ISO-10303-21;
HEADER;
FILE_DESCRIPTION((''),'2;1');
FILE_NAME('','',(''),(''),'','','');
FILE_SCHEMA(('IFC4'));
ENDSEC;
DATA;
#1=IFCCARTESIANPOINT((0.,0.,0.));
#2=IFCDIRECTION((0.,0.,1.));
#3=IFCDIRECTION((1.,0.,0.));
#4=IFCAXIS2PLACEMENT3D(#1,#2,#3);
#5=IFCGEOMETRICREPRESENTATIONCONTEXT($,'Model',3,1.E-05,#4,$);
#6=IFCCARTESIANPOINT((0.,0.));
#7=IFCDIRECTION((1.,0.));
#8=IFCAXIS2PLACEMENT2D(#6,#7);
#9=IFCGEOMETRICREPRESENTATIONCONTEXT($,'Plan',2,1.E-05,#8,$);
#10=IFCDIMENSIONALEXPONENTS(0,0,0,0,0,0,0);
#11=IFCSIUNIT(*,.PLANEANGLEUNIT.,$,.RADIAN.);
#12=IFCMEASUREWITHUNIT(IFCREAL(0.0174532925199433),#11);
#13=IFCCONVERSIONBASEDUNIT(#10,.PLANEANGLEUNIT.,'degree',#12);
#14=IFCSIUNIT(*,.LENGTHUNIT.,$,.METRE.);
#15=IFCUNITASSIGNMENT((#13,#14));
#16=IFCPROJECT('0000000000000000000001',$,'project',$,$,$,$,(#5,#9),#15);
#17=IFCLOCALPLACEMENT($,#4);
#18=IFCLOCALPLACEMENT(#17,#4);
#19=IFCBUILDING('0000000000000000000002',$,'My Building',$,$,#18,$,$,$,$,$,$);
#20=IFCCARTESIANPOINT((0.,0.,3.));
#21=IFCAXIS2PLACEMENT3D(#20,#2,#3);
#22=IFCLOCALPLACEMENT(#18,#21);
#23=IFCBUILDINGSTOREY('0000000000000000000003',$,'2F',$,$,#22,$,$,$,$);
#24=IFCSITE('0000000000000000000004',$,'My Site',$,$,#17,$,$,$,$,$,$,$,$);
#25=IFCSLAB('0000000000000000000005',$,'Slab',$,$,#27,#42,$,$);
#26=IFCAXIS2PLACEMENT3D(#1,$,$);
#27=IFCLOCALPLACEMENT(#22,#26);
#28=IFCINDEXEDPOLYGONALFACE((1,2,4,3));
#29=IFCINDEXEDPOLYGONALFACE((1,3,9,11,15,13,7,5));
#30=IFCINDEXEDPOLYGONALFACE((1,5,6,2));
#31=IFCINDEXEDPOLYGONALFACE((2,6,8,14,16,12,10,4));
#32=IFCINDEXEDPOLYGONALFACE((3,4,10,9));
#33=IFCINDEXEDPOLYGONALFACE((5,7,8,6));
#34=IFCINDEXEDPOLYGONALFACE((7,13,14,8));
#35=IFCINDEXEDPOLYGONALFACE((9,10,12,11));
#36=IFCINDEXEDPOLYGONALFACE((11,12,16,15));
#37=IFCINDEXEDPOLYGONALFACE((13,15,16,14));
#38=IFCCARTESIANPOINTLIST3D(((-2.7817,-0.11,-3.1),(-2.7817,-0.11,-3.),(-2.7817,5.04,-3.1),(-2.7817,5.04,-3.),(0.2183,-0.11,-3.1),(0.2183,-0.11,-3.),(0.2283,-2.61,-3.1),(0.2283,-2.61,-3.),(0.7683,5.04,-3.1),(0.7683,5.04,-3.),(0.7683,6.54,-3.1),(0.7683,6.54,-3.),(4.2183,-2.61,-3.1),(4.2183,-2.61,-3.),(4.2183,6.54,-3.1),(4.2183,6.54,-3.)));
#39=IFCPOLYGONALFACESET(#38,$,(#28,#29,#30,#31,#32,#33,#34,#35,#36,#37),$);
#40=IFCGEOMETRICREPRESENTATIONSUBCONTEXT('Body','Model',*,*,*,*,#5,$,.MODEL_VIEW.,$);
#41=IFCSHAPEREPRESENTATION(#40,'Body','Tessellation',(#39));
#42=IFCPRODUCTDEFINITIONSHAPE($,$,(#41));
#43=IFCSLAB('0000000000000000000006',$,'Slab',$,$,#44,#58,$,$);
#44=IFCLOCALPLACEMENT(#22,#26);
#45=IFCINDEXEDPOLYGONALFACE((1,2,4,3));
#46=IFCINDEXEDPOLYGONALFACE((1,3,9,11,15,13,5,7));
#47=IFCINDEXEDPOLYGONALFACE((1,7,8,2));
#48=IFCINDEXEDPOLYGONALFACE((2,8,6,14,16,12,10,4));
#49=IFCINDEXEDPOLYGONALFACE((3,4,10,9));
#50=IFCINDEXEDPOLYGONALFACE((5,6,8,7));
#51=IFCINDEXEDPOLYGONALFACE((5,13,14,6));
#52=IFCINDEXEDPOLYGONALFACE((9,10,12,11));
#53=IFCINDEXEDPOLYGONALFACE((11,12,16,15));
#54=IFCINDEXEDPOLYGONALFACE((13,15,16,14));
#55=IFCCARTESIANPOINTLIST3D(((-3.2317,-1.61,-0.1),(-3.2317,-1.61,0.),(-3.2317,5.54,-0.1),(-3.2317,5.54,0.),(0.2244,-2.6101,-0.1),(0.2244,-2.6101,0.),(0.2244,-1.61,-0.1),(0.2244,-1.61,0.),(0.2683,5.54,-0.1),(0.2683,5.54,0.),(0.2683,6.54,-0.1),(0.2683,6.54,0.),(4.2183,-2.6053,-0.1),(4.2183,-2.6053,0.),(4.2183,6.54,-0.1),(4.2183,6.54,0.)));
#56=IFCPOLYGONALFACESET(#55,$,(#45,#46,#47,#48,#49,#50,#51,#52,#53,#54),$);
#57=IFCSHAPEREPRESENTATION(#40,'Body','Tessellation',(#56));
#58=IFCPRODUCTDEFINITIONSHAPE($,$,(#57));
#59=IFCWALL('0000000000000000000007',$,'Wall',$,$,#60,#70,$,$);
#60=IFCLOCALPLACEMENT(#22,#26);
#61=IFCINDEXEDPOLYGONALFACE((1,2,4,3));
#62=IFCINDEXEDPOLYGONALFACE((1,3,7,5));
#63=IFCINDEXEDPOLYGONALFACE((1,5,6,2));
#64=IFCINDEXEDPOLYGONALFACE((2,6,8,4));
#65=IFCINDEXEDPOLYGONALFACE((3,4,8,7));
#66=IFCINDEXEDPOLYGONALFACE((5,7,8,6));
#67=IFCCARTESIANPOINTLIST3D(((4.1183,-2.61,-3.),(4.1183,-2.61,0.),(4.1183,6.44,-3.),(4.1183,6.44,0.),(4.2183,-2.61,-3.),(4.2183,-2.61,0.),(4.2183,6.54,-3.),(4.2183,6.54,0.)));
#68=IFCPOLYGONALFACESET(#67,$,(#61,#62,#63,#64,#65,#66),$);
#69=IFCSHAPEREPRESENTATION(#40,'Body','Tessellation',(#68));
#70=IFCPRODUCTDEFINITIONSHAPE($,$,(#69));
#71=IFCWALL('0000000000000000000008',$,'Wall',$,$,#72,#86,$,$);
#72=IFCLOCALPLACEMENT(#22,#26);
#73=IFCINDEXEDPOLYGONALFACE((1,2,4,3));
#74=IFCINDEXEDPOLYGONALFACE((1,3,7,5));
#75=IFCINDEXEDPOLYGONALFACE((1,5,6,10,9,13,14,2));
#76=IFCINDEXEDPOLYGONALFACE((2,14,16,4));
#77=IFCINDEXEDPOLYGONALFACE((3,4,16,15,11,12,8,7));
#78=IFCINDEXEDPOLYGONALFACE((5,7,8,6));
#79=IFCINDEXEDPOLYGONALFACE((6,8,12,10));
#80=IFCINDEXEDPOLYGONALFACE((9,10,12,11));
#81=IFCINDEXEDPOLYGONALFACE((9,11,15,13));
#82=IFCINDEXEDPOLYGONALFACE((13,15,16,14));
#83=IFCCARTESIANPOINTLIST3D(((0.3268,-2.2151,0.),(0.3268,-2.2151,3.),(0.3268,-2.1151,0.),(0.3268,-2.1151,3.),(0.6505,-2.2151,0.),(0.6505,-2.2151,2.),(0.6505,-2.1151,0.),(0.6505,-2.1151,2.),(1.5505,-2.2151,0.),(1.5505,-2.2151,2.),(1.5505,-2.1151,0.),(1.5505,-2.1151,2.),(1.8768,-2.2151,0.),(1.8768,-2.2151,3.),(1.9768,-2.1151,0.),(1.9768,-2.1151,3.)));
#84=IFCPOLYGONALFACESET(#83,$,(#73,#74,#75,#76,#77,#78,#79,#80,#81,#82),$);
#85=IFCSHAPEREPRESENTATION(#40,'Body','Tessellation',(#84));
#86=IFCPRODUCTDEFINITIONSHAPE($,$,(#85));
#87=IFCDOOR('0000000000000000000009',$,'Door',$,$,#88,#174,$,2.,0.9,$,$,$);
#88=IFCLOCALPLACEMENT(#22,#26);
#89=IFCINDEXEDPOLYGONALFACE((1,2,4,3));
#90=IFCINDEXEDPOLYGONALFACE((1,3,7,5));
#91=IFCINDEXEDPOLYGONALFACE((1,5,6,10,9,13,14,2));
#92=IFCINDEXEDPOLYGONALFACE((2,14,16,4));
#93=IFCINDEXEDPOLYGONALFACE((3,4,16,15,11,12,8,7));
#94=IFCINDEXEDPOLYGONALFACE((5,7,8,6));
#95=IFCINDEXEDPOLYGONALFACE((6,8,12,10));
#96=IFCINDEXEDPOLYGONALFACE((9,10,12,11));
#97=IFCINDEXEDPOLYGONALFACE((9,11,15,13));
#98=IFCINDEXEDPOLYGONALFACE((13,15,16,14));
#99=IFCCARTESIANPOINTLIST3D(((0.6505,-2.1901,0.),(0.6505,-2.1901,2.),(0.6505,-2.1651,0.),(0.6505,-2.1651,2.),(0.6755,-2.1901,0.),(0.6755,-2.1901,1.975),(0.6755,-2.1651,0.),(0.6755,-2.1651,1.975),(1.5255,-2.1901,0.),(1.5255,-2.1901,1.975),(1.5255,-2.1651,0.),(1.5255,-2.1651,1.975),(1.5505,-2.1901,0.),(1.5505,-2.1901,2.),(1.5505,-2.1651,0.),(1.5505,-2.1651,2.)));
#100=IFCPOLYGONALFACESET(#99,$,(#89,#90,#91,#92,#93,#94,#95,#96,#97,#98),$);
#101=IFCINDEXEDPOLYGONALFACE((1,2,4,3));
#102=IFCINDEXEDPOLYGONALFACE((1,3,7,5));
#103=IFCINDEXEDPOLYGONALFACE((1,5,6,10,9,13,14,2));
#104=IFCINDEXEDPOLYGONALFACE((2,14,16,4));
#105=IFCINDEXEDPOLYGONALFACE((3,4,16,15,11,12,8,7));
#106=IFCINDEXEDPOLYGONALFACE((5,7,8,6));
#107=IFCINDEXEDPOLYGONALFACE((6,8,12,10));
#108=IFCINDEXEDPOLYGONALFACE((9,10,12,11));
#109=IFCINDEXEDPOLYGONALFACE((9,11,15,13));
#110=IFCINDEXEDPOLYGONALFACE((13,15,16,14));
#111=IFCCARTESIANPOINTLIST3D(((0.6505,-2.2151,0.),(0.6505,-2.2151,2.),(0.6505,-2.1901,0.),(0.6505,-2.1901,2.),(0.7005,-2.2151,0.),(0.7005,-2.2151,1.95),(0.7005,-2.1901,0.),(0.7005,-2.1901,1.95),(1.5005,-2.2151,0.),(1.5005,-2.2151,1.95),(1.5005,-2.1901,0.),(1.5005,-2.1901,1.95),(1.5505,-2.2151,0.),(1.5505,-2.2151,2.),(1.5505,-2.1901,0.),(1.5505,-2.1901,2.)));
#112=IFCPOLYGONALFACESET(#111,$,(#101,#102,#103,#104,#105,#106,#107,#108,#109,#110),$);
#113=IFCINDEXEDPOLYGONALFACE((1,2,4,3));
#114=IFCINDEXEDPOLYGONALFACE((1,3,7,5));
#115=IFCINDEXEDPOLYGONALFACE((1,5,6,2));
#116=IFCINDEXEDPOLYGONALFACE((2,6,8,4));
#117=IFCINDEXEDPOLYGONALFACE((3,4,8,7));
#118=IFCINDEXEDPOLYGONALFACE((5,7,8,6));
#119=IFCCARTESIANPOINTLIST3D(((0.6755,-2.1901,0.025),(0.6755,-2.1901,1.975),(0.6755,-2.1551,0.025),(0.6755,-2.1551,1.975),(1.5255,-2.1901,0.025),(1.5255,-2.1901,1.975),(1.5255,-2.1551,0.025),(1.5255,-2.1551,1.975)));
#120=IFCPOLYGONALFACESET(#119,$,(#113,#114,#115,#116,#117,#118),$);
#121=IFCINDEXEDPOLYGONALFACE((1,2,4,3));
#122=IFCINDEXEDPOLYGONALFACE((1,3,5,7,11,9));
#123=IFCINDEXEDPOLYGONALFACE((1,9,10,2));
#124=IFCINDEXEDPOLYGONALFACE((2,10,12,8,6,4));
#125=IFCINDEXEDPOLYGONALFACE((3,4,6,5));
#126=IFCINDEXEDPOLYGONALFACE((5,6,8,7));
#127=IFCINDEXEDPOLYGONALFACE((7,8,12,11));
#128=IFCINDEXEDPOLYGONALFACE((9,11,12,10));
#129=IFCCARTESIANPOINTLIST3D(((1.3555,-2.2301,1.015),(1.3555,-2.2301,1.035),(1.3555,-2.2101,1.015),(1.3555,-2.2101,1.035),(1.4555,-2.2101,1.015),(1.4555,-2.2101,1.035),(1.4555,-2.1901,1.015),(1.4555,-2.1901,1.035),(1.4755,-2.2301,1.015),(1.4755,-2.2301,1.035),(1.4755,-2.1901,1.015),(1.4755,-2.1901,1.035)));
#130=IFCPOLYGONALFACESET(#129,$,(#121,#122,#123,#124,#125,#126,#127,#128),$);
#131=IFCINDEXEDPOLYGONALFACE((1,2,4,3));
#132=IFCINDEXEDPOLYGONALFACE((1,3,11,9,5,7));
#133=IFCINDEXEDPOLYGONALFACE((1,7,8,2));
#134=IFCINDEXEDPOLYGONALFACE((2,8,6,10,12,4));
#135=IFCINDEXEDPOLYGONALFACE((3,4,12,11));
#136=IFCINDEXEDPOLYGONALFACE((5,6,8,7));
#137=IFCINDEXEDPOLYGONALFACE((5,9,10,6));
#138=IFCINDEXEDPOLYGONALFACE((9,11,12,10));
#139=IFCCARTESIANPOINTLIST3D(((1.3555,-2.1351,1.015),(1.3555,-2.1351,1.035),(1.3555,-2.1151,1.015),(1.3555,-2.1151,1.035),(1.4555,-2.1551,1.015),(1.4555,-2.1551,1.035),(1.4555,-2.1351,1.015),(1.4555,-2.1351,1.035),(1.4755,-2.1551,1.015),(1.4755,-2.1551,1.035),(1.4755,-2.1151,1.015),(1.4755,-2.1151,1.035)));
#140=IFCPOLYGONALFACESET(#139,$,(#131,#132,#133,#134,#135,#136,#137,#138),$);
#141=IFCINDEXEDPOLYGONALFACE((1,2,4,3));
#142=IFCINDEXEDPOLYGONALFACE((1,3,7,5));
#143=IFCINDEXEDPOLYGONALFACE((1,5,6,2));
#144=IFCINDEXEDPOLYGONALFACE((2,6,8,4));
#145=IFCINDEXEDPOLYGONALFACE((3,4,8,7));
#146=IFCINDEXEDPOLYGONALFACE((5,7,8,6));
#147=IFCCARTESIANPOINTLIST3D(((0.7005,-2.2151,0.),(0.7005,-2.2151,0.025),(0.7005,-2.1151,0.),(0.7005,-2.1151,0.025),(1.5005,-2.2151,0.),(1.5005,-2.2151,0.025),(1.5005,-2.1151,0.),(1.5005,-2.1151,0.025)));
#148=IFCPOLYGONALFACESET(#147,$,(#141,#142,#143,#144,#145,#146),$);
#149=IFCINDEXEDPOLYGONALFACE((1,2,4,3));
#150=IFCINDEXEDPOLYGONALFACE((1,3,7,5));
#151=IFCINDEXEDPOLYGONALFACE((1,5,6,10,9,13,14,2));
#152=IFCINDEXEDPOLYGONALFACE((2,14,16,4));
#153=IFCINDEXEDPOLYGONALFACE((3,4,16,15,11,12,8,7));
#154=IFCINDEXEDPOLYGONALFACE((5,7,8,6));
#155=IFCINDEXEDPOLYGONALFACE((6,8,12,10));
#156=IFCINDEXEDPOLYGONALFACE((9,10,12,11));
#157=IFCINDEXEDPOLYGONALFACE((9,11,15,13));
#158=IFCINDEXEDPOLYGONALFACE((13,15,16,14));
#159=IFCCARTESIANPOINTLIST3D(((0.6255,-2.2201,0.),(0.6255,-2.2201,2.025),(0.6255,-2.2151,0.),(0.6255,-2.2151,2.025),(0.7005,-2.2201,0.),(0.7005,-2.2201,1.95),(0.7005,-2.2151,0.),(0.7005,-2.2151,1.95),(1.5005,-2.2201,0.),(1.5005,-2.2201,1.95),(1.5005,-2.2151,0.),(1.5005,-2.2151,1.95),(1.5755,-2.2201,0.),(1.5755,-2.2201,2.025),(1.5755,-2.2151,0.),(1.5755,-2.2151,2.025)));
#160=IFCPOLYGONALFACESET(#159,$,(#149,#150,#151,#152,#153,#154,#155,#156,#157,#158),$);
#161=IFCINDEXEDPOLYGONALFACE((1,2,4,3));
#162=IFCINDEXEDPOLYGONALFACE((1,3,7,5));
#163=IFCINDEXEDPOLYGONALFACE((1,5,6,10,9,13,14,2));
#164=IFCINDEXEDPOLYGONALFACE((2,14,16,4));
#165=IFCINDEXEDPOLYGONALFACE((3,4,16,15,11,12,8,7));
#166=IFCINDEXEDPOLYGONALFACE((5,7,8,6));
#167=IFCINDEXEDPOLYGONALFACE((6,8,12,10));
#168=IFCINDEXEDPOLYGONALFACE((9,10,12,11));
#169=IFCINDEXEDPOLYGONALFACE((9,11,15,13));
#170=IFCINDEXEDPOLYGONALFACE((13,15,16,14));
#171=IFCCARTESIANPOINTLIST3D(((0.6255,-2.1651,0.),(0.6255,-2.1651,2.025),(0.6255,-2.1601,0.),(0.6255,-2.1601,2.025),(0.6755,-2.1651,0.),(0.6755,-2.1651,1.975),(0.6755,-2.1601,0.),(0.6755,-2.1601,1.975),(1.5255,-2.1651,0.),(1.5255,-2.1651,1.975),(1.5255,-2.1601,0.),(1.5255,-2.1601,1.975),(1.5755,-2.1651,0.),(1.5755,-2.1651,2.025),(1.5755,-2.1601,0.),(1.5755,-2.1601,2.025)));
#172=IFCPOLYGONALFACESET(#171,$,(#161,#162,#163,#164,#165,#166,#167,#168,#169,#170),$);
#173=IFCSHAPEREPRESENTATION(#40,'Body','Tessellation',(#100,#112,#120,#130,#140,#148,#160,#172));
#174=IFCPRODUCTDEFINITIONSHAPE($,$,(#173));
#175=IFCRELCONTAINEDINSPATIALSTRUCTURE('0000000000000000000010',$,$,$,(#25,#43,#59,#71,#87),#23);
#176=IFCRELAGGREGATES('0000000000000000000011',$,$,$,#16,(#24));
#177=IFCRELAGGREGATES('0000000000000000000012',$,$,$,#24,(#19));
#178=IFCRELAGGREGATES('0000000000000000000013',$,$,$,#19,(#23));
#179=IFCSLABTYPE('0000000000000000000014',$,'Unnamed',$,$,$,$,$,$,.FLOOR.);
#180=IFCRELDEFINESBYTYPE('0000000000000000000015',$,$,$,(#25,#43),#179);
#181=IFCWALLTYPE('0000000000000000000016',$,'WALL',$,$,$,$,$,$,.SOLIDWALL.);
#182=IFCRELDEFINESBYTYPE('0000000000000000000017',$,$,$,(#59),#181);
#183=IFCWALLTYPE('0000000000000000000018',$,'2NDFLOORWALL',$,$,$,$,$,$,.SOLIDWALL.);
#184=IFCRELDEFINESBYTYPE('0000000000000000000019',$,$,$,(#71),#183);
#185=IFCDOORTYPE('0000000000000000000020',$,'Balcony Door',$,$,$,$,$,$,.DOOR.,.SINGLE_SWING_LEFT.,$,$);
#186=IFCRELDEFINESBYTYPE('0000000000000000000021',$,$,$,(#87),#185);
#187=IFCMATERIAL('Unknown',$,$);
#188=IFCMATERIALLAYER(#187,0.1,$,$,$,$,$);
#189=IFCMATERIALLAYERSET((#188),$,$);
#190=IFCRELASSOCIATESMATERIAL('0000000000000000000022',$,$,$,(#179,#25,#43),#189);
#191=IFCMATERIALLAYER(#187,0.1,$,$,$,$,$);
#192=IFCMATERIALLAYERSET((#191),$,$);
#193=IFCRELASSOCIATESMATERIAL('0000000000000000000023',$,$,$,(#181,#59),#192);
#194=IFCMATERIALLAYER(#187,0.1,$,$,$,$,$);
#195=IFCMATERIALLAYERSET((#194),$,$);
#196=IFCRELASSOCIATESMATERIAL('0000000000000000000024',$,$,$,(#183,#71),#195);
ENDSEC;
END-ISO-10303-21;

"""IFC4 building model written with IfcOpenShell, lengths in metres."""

from ifc_helpers import new_model, entity, si_unit, converted_unit, frame, origin_with_axes, origin_2d_with_axis, place, context, subcontext, project, spatial, line, indexed_curve, outline, extrude, shape, source, transform, mapped, material, layer, layer_set, layer_usage, type_object, type_shapes, element, fill, save


model = new_model("IFC4")

# Units and contexts
model_context = context("Model", 3, precision=1e-05, world=origin_with_axes())
plan_context = context("Plan", 2, precision=1e-05, world=origin_2d_with_axis())
body_context_1 = subcontext(model_context, "Body", "Model", "MODEL_VIEW")
body_context_2 = subcontext(plan_context, "Body", "Plan", "PLAN_VIEW")
ifc_project = project(units=[converted_unit("PLANEANGLEUNIT", "degree", entity("IfcReal", 0.0174532925199433), si_unit("PLANEANGLEUNIT", "RADIAN"), dimensions=[0, 0, 0, 0, 0, 0, 0]), si_unit("LENGTHUNIT", "METRE")], contexts=[model_context, plan_context])

# Site, building, storey
site_placement = place(None, origin_with_axes())
site = spatial("IfcSite", under=ifc_project, at=site_placement, Name="My Site")
building_placement = place(site_placement, origin_with_axes())
building = spatial("IfcBuilding", under=site, at=building_placement, Name="My Building")
storey_placement = place(building_placement, frame((0.0, 0.0, 3.0), z_axis=(0.0, 0.0, 1.0), x_axis=(1.0, 0.0, 0.0)))
storey = spatial("IfcBuildingStorey", under=building, at=storey_placement, Name="2F")

# Slabs
ifc_material = material(Name="Unknown")
ifc_layer_1 = layer(ifc_material, 0.1)
ifc_layer_set_1 = layer_set([ifc_layer_1])
ifc_layer_usage_1 = layer_usage(ifc_layer_set_1, "AXIS3", "POSITIVE", -0.1)
slab_type = type_object("IfcSlabType", Name="Unnamed", PredefinedType="FLOOR", material=ifc_layer_set_1)
slab_1_placement = place(storey_placement, frame((4.2183, -2.61, -3.0), z_axis=(0.0, 0.0, 1.0), x_axis=(1.0, 0.0, 0.0)))
element("IfcSlab", 1, at=slab_1_placement, inside=storey, type_object=slab_type, material=ifc_layer_usage_1, Name="Slab", context=body_context_1, shape_type="SweptSolid", body=[
    extrude(outline(indexed_curve([(0.0, 0.0), (0.0, 9.15), (-3.45, 9.15), (-3.45, 7.65), (-7.0, 7.65), (-7.0, 2.5), (-4.0, 2.5), (-3.99, 0.0), (0.0, 0.0)])), frame((0.0, 0.0, -0.1), z_axis=(0.0, 0.0, 1.0), x_axis=(1.0, 0.0, 0.0)), (0.0, 0.0, 1.0), 0.1),
])
ifc_layer_usage_2 = layer_usage(ifc_layer_set_1, "AXIS3", "POSITIVE", -0.1)
slab_2_placement = place(storey_placement, frame((4.2183, -2.6053, 0.0), z_axis=(0.0, 0.0, 1.0), x_axis=(1.0, 0.0, 0.0)))
element("IfcSlab", 2, at=slab_2_placement, inside=storey, type_object=slab_type, material=ifc_layer_usage_2, Name="Slab", context=body_context_1, shape_type="SweptSolid", body=[
    extrude(outline(indexed_curve([(0.0, 0.0), (-3.9939, -0.0048), (-3.9939, 0.9953), (-7.45, 0.9953), (-7.45, 8.1453), (-3.95, 8.1453), (-3.95, 9.1453), (0.0, 9.1453), (0.0, 0.0), (0.0, 0.0)])), frame((0.0, 0.0, -0.1), z_axis=(0.0, 0.0, 1.0), x_axis=(1.0, 0.0, 0.0)), (0.0, 0.0, 1.0), 0.1),
])

# Wall
ifc_layer_2 = layer(ifc_material, 0.1)
ifc_layer_set_2 = layer_set([ifc_layer_2])
ifc_layer_usage_3 = layer_usage(ifc_layer_set_2, "AXIS2", "POSITIVE", 0.0)
wall_type_1 = type_object("IfcWallType", Name="WALL", PredefinedType="SOLIDWALL", material=ifc_layer_set_2)
wall_1_placement = place(storey_placement, frame((4.2183, -2.61, -3.0), z_axis=(0.0, 0.0, 1.0), x_axis=(0.0, 1.0, 0.0)))
element("IfcWall", 3, at=wall_1_placement, inside=storey, type_object=wall_type_1, material=ifc_layer_usage_3, Name="Wall", context=body_context_1, shape_type="SweptSolid", body=[
    extrude(outline(indexed_curve([(0.0, 0.0), (0.0, 0.1), (9.05, 0.1), (9.15, 0.0)], segments=[line(1, 2, 3, 4, 1)])), origin_with_axes(), (0.0, 0.0, 1.0), 3.0),
])

# Wall, opening, door
ifc_layer_3 = layer(ifc_material, 0.1)
ifc_layer_set_3 = layer_set([ifc_layer_3])
ifc_layer_usage_4 = layer_usage(ifc_layer_set_3, "AXIS2", "POSITIVE", 0.0)
wall_type_2 = type_object("IfcWallType", Name="2NDFLOORWALL", PredefinedType="SOLIDWALL", material=ifc_layer_set_3)
wall_2_placement = place(storey_placement, frame((0.3268, -2.2151, 0.0), z_axis=(0.0, 0.0, 1.0), x_axis=(1.0, 0.0, 0.0)))
wall_2 = element("IfcWall", 4, at=wall_2_placement, inside=storey, type_object=wall_type_2, material=ifc_layer_usage_4, Name="Wall", context=body_context_1, shape_type="SweptSolid", body=[
    extrude(outline(indexed_curve([(0.0, 0.0), (0.0, 0.1), (1.65, 0.1), (1.55, 0.0)], segments=[line(1, 2, 3, 4, 1)])), origin_with_axes(), (0.0, 0.0, 1.0), 3.0),
])
shared_shape_1 = source(origin_with_axes(), body_context_1, "Body", "SweptSolid", [
    extrude(outline(indexed_curve([(0.0, 0.0), (0.9, 0.0), (0.9, 2.0), (0.0, 2.0)], segments=[line(1, 2, 3, 4, 1)])), frame((0.0, -0.6, 0.0), z_axis=(0.0, -1.0, 0.0), x_axis=(1.0, 0.0, 0.0)), (0.0, 0.0, -1.0), 1.2),
])
opening_1_placement = place(wall_2_placement, frame((0.3237, 0.0, 0.0), z_axis=(0.0, 0.0, 1.0), x_axis=(1.0, 0.0, 0.0)))
opening_1 = element("IfcOpeningElement", 5, at=opening_1_placement, cuts=wall_2, PredefinedType="OPENING", context=body_context_1, shape_type="MappedRepresentation", body=[
    mapped(shared_shape_1, transform((0.0, 0.0, 0.0), x_axis=(1.0, 0.0, 0.0), y_axis=(0.0, 1.0, 0.0), z_axis=(0.0, 0.0, 1.0), scale=1.0)),
])
door_type_1 = type_object("IfcDoorType", Name="Balcony Door", OperationType="SINGLE_SWING_LEFT", PredefinedType="DOOR")
shared_shape_2 = source(origin_with_axes(), body_context_1, "Body", "SweptSolid", [
    extrude(outline(indexed_curve([(0.0, 0.0), (0.0, 2.0), (0.9, 2.0), (0.9, 0.0), (0.875, 0.0), (0.875, 1.975), (0.025, 1.975), (0.025, 0.0)], segments=[line(1, 2, 3, 4, 5, 6, 7, 8, 1)])), frame((0.0, 0.025, 0.0), z_axis=(0.0, -1.0, 0.0), x_axis=(1.0, 0.0, 0.0)), (0.0, 0.0, -1.0), 0.025),
    extrude(outline(indexed_curve([(0.0, 0.0), (0.0, 2.0), (0.9, 2.0), (0.9, 0.0), (0.85, 0.0), (0.85, 1.95), (0.05, 1.95), (0.05, 0.0)], segments=[line(1, 2, 3, 4, 5, 6, 7, 8, 1)])), frame((0.0, 0.0, 0.0), z_axis=(0.0, -1.0, 0.0), x_axis=(1.0, 0.0, 0.0)), (0.0, 0.0, -1.0), 0.025),
    extrude(outline(indexed_curve([(0.0, 0.0), (0.85, 0.0), (0.85, 0.035), (0.0, 0.035)], segments=[line(1, 2, 3, 4, 1)])), frame((0.025, 0.025, 0.025), z_axis=(0.0, 0.0, 1.0), x_axis=(1.0, 0.0, 0.0)), (0.0, 0.0, 1.0), 1.95),
    extrude(outline(indexed_curve([(0.0, 0.0), (0.0, -0.04), (-0.12, -0.04), (-0.12, -0.02), (-0.02, -0.02), (-0.02, 0.0)], segments=[line(1, 2, 3, 4, 5, 6, 1)])), frame((0.825, 0.025, 1.015), z_axis=(0.0, 0.0, 1.0), x_axis=(1.0, 0.0, 0.0)), (0.0, 0.0, 1.0), 0.02),
    extrude(outline(indexed_curve([(0.0, 0.0), (0.0, 0.04), (-0.12, 0.04), (-0.12, 0.02), (-0.02, 0.02), (-0.02, 0.0)], segments=[line(1, 2, 3, 4, 5, 6, 1)])), frame((0.825, 0.06, 1.015), z_axis=(0.0, 0.0, 1.0), x_axis=(1.0, 0.0, 0.0)), (0.0, 0.0, 1.0), 0.02),
    extrude(outline(indexed_curve([(0.0, 0.0), (0.8, 0.0), (0.8, 0.1), (0.0, 0.1)], segments=[line(1, 2, 3, 4, 1)])), frame((0.05, 0.0, 0.0), z_axis=(0.0, 0.0, 1.0), x_axis=(1.0, 0.0, 0.0)), (0.0, 0.0, 1.0), 0.025),
    extrude(outline(indexed_curve([(0.0, 0.0), (0.0, 2.025), (0.95, 2.025), (0.95, 0.0), (0.875, 0.0), (0.875, 1.95), (0.075, 1.95), (0.075, 0.0)], segments=[line(1, 2, 3, 4, 5, 6, 7, 8, 1)])), frame((-0.025, -0.005, 0.0), z_axis=(0.0, -1.0, 0.0), x_axis=(1.0, 0.0, 0.0)), (0.0, 0.0, -1.0), 0.005),
    extrude(outline(indexed_curve([(0.0, 0.0), (0.0, 2.025), (0.95, 2.025), (0.95, 0.0), (0.9, 0.0), (0.9, 1.975), (0.05, 1.975), (0.05, 0.0)], segments=[line(1, 2, 3, 4, 5, 6, 7, 8, 1)])), frame((-0.025, 0.05, 0.0), z_axis=(0.0, -1.0, 0.0), x_axis=(1.0, 0.0, 0.0)), (0.0, 0.0, -1.0), 0.005),
])
shared_shape_3 = source(origin_with_axes(), body_context_2, "Body", "Curve2D", [
    entity("IfcIndexedPolyCurve", entity("IfcCartesianPointList2D", [[0.0, 0.0], [0.0, 0.05], [0.025, 0.05], [0.025, 0.025], [0.05, 0.025], [0.05, 0.0]]), [entity("IfcLineIndex", [1, 2, 3, 4, 5, 6, 1])]),
    entity("IfcIndexedPolyCurve", entity("IfcCartesianPointList2D", [[0.9, 0.0], [0.9, 0.05], [0.875, 0.05], [0.875, 0.025], [0.85, 0.025], [0.85, 0.0]]), [entity("IfcLineIndex", [1, 2, 3, 4, 5, 6, 1])]),
    entity("IfcTrimmedCurve", entity("IfcEllipse", entity("IfcAxis2Placement2D", entity("IfcCartesianPoint", [0.06, 0.05]), entity("IfcDirection", [1.0, 0.0])), 0.815, 0.85), [entity("IfcCartesianPoint", [0.875, 0.05])], [entity("IfcCartesianPoint", [0.06, 0.9])], True, "CARTESIAN"),
    entity("IfcIndexedPolyCurve", entity("IfcCartesianPointList2D", [[0.025, 0.05], [0.06, 0.05], [0.06, 0.9], [0.025, 0.9]]), [entity("IfcLineIndex", [1, 2, 3, 4, 1])]),
])
type_shapes(door_type_1, [shared_shape_2, shared_shape_3])
door_1_placement = place(opening_1_placement, origin_with_axes())
door_1 = element("IfcDoor", 6, at=door_1_placement, inside=storey, type_object=door_type_1, Name="Door", OverallHeight=2.0, OverallWidth=0.9, shapes=[
    shape(body_context_1, "Body", "MappedRepresentation", [mapped(shared_shape_2, transform((0.0, 0.0, 0.0), x_axis=(1.0, 0.0, 0.0), y_axis=(0.0, 1.0, 0.0), z_axis=(0.0, 0.0, 1.0), scale=1.0))]),
    shape(body_context_2, "Body", "MappedRepresentation", [mapped(shared_shape_3, transform((0.0, 0.0, 0.0), x_axis=(1.0, 0.0, 0.0), y_axis=(0.0, 1.0, 0.0), z_axis=(0.0, 0.0, 1.0), scale=1.0))]),
])
fill(opening_1, door_1)

save(model, "model.ifc")
